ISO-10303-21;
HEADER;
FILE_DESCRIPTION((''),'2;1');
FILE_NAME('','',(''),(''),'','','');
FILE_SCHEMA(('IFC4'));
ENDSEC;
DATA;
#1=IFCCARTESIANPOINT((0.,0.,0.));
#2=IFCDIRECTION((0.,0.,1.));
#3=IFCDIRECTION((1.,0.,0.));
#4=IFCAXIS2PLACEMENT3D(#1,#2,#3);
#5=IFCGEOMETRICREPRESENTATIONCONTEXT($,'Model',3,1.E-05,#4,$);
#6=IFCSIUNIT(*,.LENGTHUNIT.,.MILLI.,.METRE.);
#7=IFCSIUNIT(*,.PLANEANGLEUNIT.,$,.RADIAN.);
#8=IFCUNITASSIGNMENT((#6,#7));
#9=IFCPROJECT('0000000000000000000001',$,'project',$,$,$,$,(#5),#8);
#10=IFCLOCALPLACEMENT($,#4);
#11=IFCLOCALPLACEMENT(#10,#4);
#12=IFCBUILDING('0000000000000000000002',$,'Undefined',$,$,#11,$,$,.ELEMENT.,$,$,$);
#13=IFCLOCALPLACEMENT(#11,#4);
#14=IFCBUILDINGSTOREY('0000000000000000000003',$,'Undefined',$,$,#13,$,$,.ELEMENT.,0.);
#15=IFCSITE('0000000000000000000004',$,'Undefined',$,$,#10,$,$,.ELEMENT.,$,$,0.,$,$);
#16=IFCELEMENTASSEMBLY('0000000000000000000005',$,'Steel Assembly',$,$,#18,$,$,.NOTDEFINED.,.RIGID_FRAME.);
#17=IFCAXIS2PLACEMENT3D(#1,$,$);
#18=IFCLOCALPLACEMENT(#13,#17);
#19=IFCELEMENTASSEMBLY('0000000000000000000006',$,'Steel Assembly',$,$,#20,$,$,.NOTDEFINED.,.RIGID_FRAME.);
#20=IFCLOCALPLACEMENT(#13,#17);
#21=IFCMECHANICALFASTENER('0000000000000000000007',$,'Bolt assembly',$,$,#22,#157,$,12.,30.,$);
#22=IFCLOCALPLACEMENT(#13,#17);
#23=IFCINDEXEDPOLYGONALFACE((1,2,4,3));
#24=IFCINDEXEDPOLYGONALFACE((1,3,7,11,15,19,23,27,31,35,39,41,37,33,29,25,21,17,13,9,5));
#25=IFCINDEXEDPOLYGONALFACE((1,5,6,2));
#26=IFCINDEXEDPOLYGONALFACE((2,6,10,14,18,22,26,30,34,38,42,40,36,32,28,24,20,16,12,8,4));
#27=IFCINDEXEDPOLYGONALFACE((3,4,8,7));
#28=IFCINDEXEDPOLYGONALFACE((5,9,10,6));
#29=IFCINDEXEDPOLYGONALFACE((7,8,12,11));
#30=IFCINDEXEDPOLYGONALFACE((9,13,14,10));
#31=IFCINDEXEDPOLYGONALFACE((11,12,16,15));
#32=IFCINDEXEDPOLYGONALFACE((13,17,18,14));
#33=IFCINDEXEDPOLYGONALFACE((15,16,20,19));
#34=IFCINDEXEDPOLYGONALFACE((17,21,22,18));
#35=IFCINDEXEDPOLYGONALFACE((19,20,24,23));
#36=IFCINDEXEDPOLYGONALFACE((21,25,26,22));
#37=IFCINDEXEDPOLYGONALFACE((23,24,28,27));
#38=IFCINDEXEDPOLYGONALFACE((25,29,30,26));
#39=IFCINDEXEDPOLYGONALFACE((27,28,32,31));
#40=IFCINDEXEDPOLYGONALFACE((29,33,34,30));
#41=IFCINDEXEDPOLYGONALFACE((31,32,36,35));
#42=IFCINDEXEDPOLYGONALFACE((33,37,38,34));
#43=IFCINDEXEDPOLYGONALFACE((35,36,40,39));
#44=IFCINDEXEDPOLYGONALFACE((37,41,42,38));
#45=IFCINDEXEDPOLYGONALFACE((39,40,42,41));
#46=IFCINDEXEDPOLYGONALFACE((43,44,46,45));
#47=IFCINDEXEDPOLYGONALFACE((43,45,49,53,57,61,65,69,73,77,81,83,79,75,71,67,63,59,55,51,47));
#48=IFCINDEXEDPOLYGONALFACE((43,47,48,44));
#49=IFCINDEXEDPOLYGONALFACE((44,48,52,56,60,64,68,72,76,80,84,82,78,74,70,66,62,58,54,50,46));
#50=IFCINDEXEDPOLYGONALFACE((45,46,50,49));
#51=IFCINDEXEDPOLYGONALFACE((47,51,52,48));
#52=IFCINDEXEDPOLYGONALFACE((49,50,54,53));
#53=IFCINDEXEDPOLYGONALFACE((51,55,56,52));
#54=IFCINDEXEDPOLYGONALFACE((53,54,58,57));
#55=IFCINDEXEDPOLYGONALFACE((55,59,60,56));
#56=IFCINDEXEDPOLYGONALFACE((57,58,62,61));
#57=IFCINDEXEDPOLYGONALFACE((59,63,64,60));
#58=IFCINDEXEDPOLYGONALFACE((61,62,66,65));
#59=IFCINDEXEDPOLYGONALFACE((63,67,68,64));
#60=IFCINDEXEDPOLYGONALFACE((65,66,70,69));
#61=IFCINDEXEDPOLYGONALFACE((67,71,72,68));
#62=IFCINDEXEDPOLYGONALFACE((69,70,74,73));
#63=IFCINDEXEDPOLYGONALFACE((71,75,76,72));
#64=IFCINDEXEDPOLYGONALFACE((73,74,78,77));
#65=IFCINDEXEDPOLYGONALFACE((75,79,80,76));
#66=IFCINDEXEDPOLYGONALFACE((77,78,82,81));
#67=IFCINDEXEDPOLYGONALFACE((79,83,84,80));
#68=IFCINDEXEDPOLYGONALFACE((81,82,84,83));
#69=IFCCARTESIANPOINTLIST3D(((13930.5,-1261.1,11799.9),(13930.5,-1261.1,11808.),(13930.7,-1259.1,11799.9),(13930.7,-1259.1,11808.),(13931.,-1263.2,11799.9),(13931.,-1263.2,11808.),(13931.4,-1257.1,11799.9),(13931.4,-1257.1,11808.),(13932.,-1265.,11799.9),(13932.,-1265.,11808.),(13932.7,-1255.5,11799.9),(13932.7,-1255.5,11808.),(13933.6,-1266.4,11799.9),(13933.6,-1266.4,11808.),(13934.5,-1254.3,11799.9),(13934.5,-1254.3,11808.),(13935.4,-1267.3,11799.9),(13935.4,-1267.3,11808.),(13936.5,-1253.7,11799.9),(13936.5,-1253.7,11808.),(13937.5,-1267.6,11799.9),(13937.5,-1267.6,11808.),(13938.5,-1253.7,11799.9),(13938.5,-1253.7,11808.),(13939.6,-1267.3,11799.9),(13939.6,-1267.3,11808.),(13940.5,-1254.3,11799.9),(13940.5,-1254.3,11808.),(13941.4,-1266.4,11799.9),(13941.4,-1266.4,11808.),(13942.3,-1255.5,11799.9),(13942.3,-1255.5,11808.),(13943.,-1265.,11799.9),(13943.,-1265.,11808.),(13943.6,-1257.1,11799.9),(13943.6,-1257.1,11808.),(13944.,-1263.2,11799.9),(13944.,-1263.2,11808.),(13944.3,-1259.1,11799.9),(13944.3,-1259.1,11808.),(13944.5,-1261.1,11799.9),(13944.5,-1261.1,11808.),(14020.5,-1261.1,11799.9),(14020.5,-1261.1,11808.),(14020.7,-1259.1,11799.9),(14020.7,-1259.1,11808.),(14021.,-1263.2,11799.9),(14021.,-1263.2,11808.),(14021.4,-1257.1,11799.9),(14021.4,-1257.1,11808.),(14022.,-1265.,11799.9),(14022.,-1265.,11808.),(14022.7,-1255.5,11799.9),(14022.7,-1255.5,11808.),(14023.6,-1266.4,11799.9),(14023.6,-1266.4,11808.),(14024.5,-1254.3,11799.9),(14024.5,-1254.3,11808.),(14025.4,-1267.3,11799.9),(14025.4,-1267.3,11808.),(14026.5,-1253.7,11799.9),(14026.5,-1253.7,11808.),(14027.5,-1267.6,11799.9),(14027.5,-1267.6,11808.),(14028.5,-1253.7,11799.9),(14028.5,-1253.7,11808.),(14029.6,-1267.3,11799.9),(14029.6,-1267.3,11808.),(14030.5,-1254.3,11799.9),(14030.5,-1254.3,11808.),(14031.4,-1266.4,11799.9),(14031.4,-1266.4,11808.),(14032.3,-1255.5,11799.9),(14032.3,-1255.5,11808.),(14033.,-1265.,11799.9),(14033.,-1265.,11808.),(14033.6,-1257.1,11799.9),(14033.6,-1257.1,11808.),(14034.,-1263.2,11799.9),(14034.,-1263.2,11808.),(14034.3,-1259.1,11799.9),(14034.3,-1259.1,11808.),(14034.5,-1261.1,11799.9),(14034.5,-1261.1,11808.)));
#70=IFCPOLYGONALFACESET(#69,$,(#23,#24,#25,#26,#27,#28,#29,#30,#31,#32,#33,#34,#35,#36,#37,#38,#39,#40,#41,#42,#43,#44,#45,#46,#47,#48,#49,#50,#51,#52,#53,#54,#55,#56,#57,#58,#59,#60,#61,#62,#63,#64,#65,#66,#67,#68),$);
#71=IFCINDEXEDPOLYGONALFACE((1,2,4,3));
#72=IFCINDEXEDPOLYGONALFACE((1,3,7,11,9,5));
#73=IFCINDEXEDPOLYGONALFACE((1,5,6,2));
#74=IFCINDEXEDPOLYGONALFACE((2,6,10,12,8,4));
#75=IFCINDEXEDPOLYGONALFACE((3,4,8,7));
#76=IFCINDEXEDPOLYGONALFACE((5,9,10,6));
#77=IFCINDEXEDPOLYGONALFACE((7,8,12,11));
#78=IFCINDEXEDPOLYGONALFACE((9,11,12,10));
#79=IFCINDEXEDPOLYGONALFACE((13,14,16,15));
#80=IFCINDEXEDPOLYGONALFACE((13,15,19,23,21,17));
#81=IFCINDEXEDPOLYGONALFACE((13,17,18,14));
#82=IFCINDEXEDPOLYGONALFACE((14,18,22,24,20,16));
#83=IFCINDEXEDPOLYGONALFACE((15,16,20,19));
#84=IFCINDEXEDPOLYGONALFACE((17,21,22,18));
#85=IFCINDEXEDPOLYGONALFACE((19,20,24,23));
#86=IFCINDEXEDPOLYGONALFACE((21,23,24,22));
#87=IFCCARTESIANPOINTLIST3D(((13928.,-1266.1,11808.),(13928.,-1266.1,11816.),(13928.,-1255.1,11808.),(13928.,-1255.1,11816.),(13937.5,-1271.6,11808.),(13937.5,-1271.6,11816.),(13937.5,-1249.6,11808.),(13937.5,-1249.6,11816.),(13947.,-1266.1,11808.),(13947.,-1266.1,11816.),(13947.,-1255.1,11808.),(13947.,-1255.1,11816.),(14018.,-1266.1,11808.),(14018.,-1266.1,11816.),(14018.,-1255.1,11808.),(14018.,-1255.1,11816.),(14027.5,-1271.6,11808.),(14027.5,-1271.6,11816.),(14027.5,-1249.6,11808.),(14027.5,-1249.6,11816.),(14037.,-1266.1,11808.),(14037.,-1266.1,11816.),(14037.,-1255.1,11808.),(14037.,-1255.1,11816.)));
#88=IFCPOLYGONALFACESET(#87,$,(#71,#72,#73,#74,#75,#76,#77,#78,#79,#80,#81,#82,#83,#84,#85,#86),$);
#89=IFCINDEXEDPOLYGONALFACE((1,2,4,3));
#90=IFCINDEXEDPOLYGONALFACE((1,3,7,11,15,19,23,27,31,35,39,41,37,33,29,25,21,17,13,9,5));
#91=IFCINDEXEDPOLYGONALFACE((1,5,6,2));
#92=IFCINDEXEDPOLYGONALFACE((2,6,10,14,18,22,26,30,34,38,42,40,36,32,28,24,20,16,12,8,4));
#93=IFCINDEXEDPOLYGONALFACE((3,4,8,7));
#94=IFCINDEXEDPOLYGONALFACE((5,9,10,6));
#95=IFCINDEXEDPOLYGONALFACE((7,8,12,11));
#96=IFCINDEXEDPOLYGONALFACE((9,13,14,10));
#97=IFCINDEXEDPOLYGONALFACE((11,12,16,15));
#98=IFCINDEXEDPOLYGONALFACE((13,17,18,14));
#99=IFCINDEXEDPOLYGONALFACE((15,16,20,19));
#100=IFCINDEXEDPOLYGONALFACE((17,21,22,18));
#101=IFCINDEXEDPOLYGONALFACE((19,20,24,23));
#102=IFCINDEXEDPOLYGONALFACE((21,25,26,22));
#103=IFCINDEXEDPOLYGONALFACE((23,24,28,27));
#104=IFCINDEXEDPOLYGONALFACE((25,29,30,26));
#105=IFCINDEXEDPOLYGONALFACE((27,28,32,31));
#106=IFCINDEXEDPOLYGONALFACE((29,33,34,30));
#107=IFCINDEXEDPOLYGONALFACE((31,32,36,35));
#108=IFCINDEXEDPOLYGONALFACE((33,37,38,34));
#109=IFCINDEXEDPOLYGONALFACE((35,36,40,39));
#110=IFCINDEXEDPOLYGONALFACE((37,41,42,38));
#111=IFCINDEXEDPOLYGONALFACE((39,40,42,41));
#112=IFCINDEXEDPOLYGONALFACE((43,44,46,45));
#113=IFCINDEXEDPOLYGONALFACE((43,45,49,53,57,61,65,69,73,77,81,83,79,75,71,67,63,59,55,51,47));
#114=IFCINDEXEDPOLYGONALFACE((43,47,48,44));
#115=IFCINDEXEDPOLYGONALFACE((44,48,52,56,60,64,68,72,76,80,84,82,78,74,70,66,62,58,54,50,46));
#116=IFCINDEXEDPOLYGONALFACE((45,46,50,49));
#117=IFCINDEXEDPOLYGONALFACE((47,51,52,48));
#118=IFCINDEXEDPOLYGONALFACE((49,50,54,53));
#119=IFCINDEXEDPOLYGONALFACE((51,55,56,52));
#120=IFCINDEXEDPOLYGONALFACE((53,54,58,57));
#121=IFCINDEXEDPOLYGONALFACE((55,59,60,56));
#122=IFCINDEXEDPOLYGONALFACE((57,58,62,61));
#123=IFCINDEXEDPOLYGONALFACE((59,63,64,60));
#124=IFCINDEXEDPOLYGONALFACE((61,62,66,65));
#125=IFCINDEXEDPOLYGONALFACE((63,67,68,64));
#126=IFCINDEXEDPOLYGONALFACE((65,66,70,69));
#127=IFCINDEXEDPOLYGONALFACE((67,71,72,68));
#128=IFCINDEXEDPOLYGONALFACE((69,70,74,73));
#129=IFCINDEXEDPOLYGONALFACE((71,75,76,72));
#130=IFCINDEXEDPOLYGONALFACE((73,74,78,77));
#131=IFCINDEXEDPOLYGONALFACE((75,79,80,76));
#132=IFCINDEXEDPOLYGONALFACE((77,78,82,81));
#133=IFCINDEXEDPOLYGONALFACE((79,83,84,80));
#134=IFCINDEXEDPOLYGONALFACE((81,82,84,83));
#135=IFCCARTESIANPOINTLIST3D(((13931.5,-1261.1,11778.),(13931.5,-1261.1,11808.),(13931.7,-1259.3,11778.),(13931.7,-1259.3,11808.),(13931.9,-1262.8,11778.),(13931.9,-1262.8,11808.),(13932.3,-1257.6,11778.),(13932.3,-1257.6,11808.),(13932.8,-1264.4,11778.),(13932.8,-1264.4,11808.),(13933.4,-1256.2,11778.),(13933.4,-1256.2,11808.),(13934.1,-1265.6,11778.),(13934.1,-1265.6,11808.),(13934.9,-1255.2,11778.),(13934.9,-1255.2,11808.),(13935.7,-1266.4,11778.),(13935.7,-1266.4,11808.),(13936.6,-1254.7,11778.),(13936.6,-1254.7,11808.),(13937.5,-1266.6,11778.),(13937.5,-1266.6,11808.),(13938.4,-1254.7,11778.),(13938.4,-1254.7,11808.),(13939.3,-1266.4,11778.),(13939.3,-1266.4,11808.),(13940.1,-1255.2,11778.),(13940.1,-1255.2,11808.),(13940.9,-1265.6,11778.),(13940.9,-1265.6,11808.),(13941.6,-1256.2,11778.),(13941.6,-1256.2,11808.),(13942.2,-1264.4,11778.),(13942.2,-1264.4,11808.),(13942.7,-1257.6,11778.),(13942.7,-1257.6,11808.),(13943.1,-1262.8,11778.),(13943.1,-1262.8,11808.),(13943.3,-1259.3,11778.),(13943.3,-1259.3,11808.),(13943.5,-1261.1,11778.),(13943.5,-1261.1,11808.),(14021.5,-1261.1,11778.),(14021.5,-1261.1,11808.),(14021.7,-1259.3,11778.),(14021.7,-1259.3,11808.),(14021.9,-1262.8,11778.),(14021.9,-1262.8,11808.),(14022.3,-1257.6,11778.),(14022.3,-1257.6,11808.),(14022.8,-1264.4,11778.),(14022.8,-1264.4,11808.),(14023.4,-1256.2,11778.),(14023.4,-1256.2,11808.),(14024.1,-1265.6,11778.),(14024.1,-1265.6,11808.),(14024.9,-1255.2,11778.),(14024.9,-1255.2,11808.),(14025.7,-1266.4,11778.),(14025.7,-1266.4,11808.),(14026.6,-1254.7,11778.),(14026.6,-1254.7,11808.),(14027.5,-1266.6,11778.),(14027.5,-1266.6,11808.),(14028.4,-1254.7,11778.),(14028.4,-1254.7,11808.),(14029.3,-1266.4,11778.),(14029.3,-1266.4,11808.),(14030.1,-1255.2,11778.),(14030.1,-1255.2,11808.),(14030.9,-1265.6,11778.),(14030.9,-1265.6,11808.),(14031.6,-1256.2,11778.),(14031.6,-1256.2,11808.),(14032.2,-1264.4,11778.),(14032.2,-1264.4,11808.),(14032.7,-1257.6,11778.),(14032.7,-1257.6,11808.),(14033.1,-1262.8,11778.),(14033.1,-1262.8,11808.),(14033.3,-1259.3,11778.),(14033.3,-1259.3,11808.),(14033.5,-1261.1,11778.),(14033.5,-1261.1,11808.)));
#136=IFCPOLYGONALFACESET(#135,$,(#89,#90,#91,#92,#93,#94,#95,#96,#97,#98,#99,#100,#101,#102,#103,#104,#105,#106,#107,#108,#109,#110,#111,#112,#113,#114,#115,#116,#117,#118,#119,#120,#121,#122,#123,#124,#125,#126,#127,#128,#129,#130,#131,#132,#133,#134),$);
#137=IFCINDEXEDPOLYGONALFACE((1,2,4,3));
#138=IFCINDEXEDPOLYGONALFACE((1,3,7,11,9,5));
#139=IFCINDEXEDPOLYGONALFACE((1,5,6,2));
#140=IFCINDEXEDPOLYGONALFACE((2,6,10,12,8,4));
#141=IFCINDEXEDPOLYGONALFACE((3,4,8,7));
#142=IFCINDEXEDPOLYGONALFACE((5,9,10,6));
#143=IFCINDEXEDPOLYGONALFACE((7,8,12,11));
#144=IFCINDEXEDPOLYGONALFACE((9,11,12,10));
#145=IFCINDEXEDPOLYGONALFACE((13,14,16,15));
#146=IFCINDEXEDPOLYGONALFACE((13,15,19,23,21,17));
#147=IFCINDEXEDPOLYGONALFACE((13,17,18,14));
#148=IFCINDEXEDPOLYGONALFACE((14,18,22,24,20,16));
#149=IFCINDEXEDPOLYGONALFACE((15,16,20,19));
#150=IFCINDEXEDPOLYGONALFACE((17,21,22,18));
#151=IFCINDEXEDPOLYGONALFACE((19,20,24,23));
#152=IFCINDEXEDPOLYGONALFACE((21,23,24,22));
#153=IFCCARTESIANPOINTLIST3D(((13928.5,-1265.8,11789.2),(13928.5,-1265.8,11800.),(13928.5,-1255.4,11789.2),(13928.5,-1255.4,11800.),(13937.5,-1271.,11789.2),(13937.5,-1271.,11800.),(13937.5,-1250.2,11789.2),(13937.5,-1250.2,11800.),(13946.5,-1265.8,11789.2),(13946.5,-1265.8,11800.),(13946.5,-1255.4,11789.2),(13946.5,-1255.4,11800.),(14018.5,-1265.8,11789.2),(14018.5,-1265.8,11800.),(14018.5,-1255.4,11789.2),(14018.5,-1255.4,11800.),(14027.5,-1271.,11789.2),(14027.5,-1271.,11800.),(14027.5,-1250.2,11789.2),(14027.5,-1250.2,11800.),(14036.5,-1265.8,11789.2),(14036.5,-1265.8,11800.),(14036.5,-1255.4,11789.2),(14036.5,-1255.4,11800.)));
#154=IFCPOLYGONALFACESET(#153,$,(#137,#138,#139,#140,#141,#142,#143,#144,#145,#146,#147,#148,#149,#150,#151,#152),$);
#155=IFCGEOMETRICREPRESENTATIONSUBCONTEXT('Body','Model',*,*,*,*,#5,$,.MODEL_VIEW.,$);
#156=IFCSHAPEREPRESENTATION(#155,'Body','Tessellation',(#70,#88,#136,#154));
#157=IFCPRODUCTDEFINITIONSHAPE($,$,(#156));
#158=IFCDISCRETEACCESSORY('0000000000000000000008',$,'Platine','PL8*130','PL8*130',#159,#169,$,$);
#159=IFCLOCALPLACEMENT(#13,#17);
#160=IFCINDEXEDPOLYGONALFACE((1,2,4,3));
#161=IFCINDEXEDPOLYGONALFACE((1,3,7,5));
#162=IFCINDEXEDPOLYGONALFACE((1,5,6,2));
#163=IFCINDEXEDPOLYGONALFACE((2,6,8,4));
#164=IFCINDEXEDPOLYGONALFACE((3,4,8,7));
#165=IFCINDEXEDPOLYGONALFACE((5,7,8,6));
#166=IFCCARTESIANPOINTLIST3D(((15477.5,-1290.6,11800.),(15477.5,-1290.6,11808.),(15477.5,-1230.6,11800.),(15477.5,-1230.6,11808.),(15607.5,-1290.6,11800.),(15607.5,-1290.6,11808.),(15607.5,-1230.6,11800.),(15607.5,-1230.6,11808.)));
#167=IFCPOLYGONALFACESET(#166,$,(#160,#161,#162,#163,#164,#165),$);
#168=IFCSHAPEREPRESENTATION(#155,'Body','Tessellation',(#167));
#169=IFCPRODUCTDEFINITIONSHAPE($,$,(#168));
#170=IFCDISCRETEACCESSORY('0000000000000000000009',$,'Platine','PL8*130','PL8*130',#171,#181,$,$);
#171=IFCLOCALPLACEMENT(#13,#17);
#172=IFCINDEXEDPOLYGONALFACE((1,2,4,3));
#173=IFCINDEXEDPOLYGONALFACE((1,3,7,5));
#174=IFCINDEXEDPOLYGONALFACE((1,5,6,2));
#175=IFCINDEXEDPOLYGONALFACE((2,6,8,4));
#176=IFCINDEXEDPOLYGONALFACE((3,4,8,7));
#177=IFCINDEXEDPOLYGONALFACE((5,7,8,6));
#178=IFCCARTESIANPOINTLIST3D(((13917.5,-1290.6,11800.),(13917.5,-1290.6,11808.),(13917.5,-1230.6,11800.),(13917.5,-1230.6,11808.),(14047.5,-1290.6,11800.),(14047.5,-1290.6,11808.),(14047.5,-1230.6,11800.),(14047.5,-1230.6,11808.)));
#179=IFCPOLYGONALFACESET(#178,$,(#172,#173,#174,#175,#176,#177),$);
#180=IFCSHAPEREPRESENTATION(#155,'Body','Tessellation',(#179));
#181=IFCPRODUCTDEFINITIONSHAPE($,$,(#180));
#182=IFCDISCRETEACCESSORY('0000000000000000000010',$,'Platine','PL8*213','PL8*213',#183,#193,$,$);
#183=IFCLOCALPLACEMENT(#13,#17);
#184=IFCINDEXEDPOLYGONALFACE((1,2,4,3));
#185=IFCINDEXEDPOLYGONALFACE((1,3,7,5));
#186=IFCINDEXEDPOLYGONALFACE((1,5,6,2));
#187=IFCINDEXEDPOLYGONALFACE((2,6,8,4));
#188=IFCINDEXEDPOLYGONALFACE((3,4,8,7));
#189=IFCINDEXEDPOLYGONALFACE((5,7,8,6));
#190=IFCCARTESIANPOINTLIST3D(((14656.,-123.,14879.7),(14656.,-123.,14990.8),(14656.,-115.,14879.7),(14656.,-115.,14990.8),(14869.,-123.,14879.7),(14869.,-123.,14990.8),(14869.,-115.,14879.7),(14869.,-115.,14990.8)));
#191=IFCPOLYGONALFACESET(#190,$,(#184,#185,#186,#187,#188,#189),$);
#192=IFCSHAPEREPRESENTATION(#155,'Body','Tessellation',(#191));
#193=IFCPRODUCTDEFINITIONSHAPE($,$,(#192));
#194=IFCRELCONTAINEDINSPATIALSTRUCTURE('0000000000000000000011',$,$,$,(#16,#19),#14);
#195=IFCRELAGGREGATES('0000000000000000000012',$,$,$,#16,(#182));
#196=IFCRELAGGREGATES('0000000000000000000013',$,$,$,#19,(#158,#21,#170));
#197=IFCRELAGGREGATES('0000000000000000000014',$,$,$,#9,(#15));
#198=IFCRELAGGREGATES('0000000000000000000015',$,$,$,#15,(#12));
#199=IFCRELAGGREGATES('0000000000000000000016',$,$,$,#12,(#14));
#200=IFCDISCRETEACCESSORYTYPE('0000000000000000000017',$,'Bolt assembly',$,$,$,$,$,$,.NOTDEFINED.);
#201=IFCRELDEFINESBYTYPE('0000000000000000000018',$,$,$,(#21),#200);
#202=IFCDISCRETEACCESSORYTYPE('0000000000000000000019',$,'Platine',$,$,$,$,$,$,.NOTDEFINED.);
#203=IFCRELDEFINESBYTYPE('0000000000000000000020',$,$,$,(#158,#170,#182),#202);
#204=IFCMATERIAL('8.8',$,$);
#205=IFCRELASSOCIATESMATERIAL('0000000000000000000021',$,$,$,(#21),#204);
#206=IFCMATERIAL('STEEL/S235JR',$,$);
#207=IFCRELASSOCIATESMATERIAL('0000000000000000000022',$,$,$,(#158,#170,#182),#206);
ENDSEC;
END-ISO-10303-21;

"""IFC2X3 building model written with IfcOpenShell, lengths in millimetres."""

from ifc_helpers import new_model, si_unit, frame, origin_with_axes, origin_2d_with_axis, place, context, subcontext, project, spatial, polyline, circle, outline, extrude, source, transform, mapped, material, type_object, element, aggregate, save


model = new_model("IFC2X3")

# Units and contexts
model_context = context("Model", 3, precision=1e-05, world=origin_with_axes())
body_context = subcontext(model_context, "Body", "Model", "MODEL_VIEW")
ifc_project = project(units=[si_unit("LENGTHUNIT", "METRE", prefix="MILLI"), si_unit("PLANEANGLEUNIT", "RADIAN")], contexts=[model_context])

# Site, building, storey
site_placement = place(None, origin_with_axes())
site = spatial("IfcSite", under=ifc_project, at=site_placement, Name="Undefined", CompositionType="ELEMENT", RefElevation=0.0)
building_placement = place(site_placement, origin_with_axes())
building = spatial("IfcBuilding", under=site, at=building_placement, Name="Undefined", CompositionType="ELEMENT")
storey_placement = place(building_placement, origin_with_axes())
storey = spatial("IfcBuildingStorey", under=building, at=storey_placement, Name="Undefined", CompositionType="ELEMENT", Elevation=0.0)

# Element assembly
ifc_material_1 = material(Name="STEEL/S235JR")
assembly_1_placement = place(storey_placement, origin_with_axes())
assembly_1 = element("IfcElementAssembly", 1, at=assembly_1_placement, inside=storey, Name="Steel Assembly", AssemblyPlace="NOTDEFINED", PredefinedType="RIGID_FRAME")

# Element assembly, mechanical fastener, discrete accessories
assembly_2_placement = place(storey_placement, origin_with_axes())
assembly_2 = element("IfcElementAssembly", 2, at=assembly_2_placement, inside=storey, Name="Steel Assembly", AssemblyPlace="NOTDEFINED", PredefinedType="RIGID_FRAME")
ifc_material_2 = material(Name="8.8")
discrete_accessory_type_1 = type_object("IfcDiscreteAccessoryType", Name="Bolt assembly")
shared_shape_1 = source(origin_with_axes(), body_context, "Body", "SweptSolid", [
    extrude(circle(Radius=7.0, at=origin_2d_with_axis()), frame((0.0, 0.0, 0.0), z_axis=(0.0, 1.0, 0.0), x_axis=(1.0, 0.0, 0.0)), (0.0, 0.0, 1.0), 8.1),
    extrude(outline(polyline([(11.0, 0.0), (5.5, 9.5), (-5.5, 9.5), (-11.0, 0.0), (-5.5, -9.5), (5.5, -9.5), (11.0, 0.0)])), frame((0.0, -8.0, 0.0), z_axis=(0.0, 1.0, 0.0), x_axis=(1.0, 0.0, 0.0)), (0.0, 0.0, 1.0), 8.0),
    extrude(circle(Radius=6.0, at=origin_2d_with_axis()), frame((0.0, 0.0, 0.0), z_axis=(0.0, 1.0, 0.0), x_axis=(1.0, 0.0, 0.0)), (0.0, 0.0, 1.0), 30.0),
    extrude(outline(polyline([(10.4, 0.0), (5.2, 9.0), (-5.2, 9.0), (-10.4, 0.0), (-5.2, -9.0), (5.2, -9.0), (10.4, 0.0)])), frame((0.0, 8.0, 0.0), z_axis=(0.0, 1.0, 0.0), x_axis=(1.0, 0.0, 0.0)), (0.0, 0.0, 1.0), 10.8),
])
mechanical_fastener_1_placement = place(assembly_2_placement, frame((13982.5, -1240.6, 11808.0), z_axis=(1.0, 0.0, 0.0), x_axis=(0.0, -1.0, 0.0)))
mechanical_fastener_1 = element("IfcMechanicalFastener", 3, at=mechanical_fastener_1_placement, type_object=discrete_accessory_type_1, material=ifc_material_2, Name="Bolt assembly", NominalDiameter=12.0, NominalLength=30.0, context=body_context, shape_type="MappedRepresentation", body=[
    mapped(shared_shape_1, transform((20.0, 0.0, -45.0))),
    mapped(shared_shape_1, transform((20.0, 0.0, 45.0))),
])
discrete_accessory_type_2 = type_object("IfcDiscreteAccessoryType", Name="Platine")
discrete_accessory_1_placement = place(assembly_2_placement, frame((15542.5, -1290.6, 11804.0), z_axis=(0.0, 0.0, 1.0), x_axis=(0.0, 1.0, 0.0)))
discrete_accessory_1 = element("IfcDiscreteAccessory", 4, at=discrete_accessory_1_placement, type_object=discrete_accessory_type_2, material=ifc_material_1, Name="Platine", Description="PL8*130", ObjectType="PL8*130", context=body_context, shape_type="SweptSolid", body=[
    extrude(outline(polyline([(60.0, 65.0), (60.0, -65.0), (0.0, -65.0), (0.0, 65.0), (60.0, 65.0)])), frame((0.0, 0.0, -4.0), z_axis=(0.0, 0.0, 1.0), x_axis=(1.0, 0.0, 0.0)), (0.0, 0.0, 1.0), 8.0),
])
discrete_accessory_2_placement = place(assembly_2_placement, frame((13982.5, -1290.6, 11804.0), z_axis=(0.0, 0.0, 1.0), x_axis=(0.0, 1.0, 0.0)))
discrete_accessory_2 = element("IfcDiscreteAccessory", 5, at=discrete_accessory_2_placement, type_object=discrete_accessory_type_2, material=ifc_material_1, Name="Platine", Description="PL8*130", ObjectType="PL8*130", context=body_context, shape_type="SweptSolid", body=[
    extrude(outline(polyline([(60.0, 65.0), (60.0, -65.0), (0.0, -65.0), (0.0, 65.0), (60.0, 65.0)])), frame((0.0, 0.0, -4.0), z_axis=(0.0, 0.0, 1.0), x_axis=(1.0, 0.0, 0.0)), (0.0, 0.0, 1.0), 8.0),
])

# Discrete accessory
discrete_accessory_3_placement = place(assembly_1_placement, frame((14762.5, -119.0, 14879.7), z_axis=(0.0, -1.0, 0.0), x_axis=(0.0, 0.0, 1.0)))
discrete_accessory_3 = element("IfcDiscreteAccessory", 6, at=discrete_accessory_3_placement, type_object=discrete_accessory_type_2, material=ifc_material_1, Name="Platine", Description="PL8*213", ObjectType="PL8*213", context=body_context, shape_type="SweptSolid", body=[
    extrude(outline(polyline([(111.1, 106.5), (111.1, -106.5), (0.0, -106.5), (0.0, 106.5), (111.1, 106.5)])), frame((0.0, 0.0, -4.0), z_axis=(0.0, 0.0, 1.0), x_axis=(1.0, 0.0, 0.0)), (0.0, 0.0, 1.0), 8.0),
])

aggregate(assembly_1, [discrete_accessory_3])

aggregate(assembly_2, [discrete_accessory_1, mechanical_fastener_1, discrete_accessory_2])

save(model, "model.ifc")
